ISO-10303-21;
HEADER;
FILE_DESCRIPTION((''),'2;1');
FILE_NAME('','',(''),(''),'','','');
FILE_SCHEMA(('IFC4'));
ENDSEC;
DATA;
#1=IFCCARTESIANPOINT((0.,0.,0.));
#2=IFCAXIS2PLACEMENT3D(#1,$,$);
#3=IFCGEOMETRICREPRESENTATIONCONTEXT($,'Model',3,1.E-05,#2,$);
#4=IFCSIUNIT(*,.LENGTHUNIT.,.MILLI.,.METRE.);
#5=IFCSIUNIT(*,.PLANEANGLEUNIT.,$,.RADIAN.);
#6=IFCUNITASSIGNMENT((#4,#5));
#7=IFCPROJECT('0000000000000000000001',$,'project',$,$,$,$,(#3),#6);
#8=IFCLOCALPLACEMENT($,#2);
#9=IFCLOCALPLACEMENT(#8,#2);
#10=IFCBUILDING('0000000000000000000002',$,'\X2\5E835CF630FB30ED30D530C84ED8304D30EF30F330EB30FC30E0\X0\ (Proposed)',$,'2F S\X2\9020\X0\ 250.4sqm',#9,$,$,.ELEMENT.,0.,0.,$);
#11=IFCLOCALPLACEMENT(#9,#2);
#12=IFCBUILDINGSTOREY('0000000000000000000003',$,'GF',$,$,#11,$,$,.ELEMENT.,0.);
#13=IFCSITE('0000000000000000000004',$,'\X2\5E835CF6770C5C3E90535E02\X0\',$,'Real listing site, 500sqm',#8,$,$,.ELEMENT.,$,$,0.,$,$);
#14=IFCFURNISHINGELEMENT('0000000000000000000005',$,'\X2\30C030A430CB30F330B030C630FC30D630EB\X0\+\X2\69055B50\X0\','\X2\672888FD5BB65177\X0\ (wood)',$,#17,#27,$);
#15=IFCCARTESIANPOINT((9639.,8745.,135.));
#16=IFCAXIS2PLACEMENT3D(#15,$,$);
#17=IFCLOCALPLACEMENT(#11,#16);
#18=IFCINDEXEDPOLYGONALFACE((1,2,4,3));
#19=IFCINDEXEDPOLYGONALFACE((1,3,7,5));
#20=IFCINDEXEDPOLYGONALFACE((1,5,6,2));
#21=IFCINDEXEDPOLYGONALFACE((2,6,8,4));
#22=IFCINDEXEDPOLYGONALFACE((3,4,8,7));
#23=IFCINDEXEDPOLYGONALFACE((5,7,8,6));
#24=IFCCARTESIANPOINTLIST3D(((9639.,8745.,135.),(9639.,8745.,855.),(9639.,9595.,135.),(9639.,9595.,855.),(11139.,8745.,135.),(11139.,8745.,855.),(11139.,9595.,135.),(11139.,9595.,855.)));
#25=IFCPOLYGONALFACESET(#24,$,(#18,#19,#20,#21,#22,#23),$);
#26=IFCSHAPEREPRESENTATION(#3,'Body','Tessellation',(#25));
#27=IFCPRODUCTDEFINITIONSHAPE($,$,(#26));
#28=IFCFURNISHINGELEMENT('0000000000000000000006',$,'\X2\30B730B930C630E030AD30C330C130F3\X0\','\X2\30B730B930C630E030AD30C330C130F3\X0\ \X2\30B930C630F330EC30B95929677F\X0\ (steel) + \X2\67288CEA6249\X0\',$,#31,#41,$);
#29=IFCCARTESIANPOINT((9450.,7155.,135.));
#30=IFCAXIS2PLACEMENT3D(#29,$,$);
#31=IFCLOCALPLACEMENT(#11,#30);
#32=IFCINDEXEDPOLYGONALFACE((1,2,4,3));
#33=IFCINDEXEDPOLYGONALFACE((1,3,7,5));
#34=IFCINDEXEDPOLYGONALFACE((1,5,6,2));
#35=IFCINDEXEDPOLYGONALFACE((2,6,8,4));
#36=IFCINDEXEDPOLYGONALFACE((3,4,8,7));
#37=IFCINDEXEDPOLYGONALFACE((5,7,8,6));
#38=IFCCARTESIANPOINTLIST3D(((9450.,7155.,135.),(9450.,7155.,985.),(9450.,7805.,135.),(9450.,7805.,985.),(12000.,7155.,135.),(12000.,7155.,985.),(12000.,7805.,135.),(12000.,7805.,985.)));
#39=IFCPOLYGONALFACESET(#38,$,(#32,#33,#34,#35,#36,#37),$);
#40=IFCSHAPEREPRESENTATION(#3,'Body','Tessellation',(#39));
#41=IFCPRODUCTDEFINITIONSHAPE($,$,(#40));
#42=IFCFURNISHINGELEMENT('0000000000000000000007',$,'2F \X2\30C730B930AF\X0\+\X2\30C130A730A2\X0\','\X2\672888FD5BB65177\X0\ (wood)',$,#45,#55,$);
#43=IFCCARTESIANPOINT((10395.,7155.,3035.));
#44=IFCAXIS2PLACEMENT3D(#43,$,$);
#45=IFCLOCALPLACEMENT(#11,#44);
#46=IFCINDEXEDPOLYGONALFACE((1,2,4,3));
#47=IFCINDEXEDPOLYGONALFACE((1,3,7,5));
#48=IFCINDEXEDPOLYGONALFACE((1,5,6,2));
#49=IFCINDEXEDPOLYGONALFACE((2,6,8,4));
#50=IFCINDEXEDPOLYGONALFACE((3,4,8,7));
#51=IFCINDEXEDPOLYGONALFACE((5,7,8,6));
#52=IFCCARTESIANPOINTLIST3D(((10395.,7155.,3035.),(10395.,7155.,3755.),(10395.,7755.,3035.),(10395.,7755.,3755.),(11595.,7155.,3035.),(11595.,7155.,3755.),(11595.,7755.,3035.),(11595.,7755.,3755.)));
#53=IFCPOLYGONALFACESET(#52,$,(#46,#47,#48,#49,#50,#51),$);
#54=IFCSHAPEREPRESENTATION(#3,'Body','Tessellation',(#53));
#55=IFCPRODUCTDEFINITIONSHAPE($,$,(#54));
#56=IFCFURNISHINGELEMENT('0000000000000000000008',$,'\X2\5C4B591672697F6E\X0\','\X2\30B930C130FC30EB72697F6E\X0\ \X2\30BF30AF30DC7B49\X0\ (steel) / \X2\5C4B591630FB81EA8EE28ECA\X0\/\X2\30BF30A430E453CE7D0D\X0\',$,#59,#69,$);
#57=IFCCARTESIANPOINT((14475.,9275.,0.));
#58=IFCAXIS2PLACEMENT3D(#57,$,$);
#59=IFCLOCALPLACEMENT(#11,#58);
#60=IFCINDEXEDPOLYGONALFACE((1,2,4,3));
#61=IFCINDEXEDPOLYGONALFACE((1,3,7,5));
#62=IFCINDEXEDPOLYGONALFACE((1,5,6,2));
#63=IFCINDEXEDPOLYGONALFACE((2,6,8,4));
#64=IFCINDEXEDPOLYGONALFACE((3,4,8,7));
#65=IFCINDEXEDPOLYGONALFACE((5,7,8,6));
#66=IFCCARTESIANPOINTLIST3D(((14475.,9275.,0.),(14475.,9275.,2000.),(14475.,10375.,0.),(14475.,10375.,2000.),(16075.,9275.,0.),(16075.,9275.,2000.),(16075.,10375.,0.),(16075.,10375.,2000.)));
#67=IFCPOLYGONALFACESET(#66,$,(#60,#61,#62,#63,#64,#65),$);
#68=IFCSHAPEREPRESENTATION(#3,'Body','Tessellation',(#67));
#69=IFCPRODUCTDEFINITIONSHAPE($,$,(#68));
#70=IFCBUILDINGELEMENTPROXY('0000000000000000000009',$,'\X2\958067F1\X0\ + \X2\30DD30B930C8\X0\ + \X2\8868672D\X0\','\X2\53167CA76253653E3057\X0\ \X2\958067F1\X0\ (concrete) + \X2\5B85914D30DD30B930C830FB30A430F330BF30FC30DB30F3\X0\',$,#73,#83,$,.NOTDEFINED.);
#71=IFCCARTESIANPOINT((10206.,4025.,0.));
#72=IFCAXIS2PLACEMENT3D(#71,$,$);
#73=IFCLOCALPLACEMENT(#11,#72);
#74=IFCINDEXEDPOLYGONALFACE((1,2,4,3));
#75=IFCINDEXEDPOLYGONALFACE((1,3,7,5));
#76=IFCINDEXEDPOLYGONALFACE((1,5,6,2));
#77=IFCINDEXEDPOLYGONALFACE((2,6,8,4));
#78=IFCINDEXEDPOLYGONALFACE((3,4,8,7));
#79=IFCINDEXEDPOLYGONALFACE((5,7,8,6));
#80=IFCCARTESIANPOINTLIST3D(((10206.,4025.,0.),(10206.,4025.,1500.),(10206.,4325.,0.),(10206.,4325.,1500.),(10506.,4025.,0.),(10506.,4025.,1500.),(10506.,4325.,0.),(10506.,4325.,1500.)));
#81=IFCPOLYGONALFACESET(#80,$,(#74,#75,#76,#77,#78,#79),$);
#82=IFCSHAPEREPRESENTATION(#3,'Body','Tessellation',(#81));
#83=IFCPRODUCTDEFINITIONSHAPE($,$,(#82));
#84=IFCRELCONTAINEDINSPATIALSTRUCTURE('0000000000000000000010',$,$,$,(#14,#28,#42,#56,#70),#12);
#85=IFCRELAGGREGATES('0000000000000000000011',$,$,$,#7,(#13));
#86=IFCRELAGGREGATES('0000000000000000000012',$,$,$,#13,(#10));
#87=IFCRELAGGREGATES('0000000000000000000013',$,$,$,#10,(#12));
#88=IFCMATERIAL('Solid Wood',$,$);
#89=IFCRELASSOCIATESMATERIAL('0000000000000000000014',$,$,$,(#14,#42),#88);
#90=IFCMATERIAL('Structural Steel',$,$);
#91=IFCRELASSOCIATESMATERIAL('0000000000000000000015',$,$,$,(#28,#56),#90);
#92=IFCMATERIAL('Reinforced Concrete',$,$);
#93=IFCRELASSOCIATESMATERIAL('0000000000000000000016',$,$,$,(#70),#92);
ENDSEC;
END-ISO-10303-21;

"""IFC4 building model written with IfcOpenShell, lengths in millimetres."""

from ifc_helpers import new_model, si_unit, frame, frame_2d, origin, place, context, project, spatial, rectangle, extrude, material, element, save


model = new_model("IFC4")

# Units and contexts
model_context = context("Model", 3, precision=1e-05, world=origin())
ifc_project = project(units=[si_unit("LENGTHUNIT", "METRE", prefix="MILLI"), si_unit("PLANEANGLEUNIT", "RADIAN")], contexts=[model_context])

# Site, building, storey
site_placement = place(None, origin())
site = spatial("IfcSite", under=ifc_project, at=site_placement, Name="広島県尾道市", ObjectType="Real listing site, 500sqm", CompositionType="ELEMENT", RefElevation=0.0)
building_placement = place(site_placement, origin())
building = spatial("IfcBuilding", under=site, at=building_placement, Name="広島・ロフト付きワンルーム (Proposed)", ObjectType="2F S造 250.4sqm", CompositionType="ELEMENT", ElevationOfRefHeight=0.0, ElevationOfTerrain=0.0)
storey_placement = place(building_placement, origin())
storey = spatial("IfcBuildingStorey", under=building, at=storey_placement, Name="GF", CompositionType="ELEMENT", Elevation=0.0)

# Shared definitions
ifc_material_1 = material(Name="Solid Wood")

# Shared definitions
ifc_material_2 = material(Name="Reinforced Concrete")

# Shared definitions
ifc_material_3 = material(Name="Structural Steel")

# Furnishing elements
furnishing_1_placement = place(storey_placement, frame((9639.0, 8745.0, 135.0)))
element("IfcFurnishingElement", 1, at=furnishing_1_placement, inside=storey, material=ifc_material_1, Name="ダイニングテーブル+椅子", Description="木製家具 (wood)", context=model_context, shape_type="SweptSolid", body=[
    extrude(rectangle(XDim=1500.0, YDim=850.0, at=frame_2d((750.0, 425.0))), frame((9639.0, 8745.0, 135.0)), (0.0, 0.0, 1.0), 720.0),
])
furnishing_2_placement = place(storey_placement, frame((9450.0, 7155.0, 135.0)))
element("IfcFurnishingElement", 2, at=furnishing_2_placement, inside=storey, material=ifc_material_3, Name="システムキッチン", Description="システムキッチン ステンレス天板 (steel) + 木質扉", context=model_context, shape_type="SweptSolid", body=[
    extrude(rectangle(XDim=2550.0, YDim=650.0, at=frame_2d((1275.0, 325.0))), frame((9450.0, 7155.0, 135.0)), (0.0, 0.0, 1.0), 850.0),
])
furnishing_3_placement = place(storey_placement, frame((10395.0, 7155.0, 3035.0)))
element("IfcFurnishingElement", 3, at=furnishing_3_placement, inside=storey, material=ifc_material_1, Name="2F デスク+チェア", Description="木製家具 (wood)", context=model_context, shape_type="SweptSolid", body=[
    extrude(rectangle(XDim=1200.0, YDim=600.0, at=frame_2d((600.0, 300.0))), frame((10395.0, 7155.0, 3035.0)), (0.0, 0.0, 1.0), 720.0),
])
furnishing_4_placement = place(storey_placement, frame((14475.0, 9275.0, 0.0)))
element("IfcFurnishingElement", 4, at=furnishing_4_placement, inside=storey, material=ifc_material_3, Name="屋外物置", Description="スチール物置 タクボ等 (steel) / 屋外・自転車/タイヤ収納", context=model_context, shape_type="SweptSolid", body=[
    extrude(rectangle(XDim=1600.0, YDim=1100.0, at=frame_2d((800.0, 550.0))), frame((14475.0, 9275.0, 0.0)), (0.0, 0.0, 1.0), 2000.0),
])

# Building element proxy
proxy_placement = place(storey_placement, frame((10206.0, 4025.0, 0.0)))
element("IfcBuildingElementProxy", 5, at=proxy_placement, inside=storey, material=ifc_material_2, Name="門柱 + ポスト + 表札", Description="化粧打放し 門柱 (concrete) + 宅配ポスト・インターホン", PredefinedType="NOTDEFINED", context=model_context, shape_type="SweptSolid", body=[
    extrude(rectangle(XDim=300.0, YDim=300.0, at=frame_2d((150.0, 150.0))), frame((10206.0, 4025.0, 0.0)), (0.0, 0.0, 1.0), 1500.0),
])

save(model, "model.ifc")
